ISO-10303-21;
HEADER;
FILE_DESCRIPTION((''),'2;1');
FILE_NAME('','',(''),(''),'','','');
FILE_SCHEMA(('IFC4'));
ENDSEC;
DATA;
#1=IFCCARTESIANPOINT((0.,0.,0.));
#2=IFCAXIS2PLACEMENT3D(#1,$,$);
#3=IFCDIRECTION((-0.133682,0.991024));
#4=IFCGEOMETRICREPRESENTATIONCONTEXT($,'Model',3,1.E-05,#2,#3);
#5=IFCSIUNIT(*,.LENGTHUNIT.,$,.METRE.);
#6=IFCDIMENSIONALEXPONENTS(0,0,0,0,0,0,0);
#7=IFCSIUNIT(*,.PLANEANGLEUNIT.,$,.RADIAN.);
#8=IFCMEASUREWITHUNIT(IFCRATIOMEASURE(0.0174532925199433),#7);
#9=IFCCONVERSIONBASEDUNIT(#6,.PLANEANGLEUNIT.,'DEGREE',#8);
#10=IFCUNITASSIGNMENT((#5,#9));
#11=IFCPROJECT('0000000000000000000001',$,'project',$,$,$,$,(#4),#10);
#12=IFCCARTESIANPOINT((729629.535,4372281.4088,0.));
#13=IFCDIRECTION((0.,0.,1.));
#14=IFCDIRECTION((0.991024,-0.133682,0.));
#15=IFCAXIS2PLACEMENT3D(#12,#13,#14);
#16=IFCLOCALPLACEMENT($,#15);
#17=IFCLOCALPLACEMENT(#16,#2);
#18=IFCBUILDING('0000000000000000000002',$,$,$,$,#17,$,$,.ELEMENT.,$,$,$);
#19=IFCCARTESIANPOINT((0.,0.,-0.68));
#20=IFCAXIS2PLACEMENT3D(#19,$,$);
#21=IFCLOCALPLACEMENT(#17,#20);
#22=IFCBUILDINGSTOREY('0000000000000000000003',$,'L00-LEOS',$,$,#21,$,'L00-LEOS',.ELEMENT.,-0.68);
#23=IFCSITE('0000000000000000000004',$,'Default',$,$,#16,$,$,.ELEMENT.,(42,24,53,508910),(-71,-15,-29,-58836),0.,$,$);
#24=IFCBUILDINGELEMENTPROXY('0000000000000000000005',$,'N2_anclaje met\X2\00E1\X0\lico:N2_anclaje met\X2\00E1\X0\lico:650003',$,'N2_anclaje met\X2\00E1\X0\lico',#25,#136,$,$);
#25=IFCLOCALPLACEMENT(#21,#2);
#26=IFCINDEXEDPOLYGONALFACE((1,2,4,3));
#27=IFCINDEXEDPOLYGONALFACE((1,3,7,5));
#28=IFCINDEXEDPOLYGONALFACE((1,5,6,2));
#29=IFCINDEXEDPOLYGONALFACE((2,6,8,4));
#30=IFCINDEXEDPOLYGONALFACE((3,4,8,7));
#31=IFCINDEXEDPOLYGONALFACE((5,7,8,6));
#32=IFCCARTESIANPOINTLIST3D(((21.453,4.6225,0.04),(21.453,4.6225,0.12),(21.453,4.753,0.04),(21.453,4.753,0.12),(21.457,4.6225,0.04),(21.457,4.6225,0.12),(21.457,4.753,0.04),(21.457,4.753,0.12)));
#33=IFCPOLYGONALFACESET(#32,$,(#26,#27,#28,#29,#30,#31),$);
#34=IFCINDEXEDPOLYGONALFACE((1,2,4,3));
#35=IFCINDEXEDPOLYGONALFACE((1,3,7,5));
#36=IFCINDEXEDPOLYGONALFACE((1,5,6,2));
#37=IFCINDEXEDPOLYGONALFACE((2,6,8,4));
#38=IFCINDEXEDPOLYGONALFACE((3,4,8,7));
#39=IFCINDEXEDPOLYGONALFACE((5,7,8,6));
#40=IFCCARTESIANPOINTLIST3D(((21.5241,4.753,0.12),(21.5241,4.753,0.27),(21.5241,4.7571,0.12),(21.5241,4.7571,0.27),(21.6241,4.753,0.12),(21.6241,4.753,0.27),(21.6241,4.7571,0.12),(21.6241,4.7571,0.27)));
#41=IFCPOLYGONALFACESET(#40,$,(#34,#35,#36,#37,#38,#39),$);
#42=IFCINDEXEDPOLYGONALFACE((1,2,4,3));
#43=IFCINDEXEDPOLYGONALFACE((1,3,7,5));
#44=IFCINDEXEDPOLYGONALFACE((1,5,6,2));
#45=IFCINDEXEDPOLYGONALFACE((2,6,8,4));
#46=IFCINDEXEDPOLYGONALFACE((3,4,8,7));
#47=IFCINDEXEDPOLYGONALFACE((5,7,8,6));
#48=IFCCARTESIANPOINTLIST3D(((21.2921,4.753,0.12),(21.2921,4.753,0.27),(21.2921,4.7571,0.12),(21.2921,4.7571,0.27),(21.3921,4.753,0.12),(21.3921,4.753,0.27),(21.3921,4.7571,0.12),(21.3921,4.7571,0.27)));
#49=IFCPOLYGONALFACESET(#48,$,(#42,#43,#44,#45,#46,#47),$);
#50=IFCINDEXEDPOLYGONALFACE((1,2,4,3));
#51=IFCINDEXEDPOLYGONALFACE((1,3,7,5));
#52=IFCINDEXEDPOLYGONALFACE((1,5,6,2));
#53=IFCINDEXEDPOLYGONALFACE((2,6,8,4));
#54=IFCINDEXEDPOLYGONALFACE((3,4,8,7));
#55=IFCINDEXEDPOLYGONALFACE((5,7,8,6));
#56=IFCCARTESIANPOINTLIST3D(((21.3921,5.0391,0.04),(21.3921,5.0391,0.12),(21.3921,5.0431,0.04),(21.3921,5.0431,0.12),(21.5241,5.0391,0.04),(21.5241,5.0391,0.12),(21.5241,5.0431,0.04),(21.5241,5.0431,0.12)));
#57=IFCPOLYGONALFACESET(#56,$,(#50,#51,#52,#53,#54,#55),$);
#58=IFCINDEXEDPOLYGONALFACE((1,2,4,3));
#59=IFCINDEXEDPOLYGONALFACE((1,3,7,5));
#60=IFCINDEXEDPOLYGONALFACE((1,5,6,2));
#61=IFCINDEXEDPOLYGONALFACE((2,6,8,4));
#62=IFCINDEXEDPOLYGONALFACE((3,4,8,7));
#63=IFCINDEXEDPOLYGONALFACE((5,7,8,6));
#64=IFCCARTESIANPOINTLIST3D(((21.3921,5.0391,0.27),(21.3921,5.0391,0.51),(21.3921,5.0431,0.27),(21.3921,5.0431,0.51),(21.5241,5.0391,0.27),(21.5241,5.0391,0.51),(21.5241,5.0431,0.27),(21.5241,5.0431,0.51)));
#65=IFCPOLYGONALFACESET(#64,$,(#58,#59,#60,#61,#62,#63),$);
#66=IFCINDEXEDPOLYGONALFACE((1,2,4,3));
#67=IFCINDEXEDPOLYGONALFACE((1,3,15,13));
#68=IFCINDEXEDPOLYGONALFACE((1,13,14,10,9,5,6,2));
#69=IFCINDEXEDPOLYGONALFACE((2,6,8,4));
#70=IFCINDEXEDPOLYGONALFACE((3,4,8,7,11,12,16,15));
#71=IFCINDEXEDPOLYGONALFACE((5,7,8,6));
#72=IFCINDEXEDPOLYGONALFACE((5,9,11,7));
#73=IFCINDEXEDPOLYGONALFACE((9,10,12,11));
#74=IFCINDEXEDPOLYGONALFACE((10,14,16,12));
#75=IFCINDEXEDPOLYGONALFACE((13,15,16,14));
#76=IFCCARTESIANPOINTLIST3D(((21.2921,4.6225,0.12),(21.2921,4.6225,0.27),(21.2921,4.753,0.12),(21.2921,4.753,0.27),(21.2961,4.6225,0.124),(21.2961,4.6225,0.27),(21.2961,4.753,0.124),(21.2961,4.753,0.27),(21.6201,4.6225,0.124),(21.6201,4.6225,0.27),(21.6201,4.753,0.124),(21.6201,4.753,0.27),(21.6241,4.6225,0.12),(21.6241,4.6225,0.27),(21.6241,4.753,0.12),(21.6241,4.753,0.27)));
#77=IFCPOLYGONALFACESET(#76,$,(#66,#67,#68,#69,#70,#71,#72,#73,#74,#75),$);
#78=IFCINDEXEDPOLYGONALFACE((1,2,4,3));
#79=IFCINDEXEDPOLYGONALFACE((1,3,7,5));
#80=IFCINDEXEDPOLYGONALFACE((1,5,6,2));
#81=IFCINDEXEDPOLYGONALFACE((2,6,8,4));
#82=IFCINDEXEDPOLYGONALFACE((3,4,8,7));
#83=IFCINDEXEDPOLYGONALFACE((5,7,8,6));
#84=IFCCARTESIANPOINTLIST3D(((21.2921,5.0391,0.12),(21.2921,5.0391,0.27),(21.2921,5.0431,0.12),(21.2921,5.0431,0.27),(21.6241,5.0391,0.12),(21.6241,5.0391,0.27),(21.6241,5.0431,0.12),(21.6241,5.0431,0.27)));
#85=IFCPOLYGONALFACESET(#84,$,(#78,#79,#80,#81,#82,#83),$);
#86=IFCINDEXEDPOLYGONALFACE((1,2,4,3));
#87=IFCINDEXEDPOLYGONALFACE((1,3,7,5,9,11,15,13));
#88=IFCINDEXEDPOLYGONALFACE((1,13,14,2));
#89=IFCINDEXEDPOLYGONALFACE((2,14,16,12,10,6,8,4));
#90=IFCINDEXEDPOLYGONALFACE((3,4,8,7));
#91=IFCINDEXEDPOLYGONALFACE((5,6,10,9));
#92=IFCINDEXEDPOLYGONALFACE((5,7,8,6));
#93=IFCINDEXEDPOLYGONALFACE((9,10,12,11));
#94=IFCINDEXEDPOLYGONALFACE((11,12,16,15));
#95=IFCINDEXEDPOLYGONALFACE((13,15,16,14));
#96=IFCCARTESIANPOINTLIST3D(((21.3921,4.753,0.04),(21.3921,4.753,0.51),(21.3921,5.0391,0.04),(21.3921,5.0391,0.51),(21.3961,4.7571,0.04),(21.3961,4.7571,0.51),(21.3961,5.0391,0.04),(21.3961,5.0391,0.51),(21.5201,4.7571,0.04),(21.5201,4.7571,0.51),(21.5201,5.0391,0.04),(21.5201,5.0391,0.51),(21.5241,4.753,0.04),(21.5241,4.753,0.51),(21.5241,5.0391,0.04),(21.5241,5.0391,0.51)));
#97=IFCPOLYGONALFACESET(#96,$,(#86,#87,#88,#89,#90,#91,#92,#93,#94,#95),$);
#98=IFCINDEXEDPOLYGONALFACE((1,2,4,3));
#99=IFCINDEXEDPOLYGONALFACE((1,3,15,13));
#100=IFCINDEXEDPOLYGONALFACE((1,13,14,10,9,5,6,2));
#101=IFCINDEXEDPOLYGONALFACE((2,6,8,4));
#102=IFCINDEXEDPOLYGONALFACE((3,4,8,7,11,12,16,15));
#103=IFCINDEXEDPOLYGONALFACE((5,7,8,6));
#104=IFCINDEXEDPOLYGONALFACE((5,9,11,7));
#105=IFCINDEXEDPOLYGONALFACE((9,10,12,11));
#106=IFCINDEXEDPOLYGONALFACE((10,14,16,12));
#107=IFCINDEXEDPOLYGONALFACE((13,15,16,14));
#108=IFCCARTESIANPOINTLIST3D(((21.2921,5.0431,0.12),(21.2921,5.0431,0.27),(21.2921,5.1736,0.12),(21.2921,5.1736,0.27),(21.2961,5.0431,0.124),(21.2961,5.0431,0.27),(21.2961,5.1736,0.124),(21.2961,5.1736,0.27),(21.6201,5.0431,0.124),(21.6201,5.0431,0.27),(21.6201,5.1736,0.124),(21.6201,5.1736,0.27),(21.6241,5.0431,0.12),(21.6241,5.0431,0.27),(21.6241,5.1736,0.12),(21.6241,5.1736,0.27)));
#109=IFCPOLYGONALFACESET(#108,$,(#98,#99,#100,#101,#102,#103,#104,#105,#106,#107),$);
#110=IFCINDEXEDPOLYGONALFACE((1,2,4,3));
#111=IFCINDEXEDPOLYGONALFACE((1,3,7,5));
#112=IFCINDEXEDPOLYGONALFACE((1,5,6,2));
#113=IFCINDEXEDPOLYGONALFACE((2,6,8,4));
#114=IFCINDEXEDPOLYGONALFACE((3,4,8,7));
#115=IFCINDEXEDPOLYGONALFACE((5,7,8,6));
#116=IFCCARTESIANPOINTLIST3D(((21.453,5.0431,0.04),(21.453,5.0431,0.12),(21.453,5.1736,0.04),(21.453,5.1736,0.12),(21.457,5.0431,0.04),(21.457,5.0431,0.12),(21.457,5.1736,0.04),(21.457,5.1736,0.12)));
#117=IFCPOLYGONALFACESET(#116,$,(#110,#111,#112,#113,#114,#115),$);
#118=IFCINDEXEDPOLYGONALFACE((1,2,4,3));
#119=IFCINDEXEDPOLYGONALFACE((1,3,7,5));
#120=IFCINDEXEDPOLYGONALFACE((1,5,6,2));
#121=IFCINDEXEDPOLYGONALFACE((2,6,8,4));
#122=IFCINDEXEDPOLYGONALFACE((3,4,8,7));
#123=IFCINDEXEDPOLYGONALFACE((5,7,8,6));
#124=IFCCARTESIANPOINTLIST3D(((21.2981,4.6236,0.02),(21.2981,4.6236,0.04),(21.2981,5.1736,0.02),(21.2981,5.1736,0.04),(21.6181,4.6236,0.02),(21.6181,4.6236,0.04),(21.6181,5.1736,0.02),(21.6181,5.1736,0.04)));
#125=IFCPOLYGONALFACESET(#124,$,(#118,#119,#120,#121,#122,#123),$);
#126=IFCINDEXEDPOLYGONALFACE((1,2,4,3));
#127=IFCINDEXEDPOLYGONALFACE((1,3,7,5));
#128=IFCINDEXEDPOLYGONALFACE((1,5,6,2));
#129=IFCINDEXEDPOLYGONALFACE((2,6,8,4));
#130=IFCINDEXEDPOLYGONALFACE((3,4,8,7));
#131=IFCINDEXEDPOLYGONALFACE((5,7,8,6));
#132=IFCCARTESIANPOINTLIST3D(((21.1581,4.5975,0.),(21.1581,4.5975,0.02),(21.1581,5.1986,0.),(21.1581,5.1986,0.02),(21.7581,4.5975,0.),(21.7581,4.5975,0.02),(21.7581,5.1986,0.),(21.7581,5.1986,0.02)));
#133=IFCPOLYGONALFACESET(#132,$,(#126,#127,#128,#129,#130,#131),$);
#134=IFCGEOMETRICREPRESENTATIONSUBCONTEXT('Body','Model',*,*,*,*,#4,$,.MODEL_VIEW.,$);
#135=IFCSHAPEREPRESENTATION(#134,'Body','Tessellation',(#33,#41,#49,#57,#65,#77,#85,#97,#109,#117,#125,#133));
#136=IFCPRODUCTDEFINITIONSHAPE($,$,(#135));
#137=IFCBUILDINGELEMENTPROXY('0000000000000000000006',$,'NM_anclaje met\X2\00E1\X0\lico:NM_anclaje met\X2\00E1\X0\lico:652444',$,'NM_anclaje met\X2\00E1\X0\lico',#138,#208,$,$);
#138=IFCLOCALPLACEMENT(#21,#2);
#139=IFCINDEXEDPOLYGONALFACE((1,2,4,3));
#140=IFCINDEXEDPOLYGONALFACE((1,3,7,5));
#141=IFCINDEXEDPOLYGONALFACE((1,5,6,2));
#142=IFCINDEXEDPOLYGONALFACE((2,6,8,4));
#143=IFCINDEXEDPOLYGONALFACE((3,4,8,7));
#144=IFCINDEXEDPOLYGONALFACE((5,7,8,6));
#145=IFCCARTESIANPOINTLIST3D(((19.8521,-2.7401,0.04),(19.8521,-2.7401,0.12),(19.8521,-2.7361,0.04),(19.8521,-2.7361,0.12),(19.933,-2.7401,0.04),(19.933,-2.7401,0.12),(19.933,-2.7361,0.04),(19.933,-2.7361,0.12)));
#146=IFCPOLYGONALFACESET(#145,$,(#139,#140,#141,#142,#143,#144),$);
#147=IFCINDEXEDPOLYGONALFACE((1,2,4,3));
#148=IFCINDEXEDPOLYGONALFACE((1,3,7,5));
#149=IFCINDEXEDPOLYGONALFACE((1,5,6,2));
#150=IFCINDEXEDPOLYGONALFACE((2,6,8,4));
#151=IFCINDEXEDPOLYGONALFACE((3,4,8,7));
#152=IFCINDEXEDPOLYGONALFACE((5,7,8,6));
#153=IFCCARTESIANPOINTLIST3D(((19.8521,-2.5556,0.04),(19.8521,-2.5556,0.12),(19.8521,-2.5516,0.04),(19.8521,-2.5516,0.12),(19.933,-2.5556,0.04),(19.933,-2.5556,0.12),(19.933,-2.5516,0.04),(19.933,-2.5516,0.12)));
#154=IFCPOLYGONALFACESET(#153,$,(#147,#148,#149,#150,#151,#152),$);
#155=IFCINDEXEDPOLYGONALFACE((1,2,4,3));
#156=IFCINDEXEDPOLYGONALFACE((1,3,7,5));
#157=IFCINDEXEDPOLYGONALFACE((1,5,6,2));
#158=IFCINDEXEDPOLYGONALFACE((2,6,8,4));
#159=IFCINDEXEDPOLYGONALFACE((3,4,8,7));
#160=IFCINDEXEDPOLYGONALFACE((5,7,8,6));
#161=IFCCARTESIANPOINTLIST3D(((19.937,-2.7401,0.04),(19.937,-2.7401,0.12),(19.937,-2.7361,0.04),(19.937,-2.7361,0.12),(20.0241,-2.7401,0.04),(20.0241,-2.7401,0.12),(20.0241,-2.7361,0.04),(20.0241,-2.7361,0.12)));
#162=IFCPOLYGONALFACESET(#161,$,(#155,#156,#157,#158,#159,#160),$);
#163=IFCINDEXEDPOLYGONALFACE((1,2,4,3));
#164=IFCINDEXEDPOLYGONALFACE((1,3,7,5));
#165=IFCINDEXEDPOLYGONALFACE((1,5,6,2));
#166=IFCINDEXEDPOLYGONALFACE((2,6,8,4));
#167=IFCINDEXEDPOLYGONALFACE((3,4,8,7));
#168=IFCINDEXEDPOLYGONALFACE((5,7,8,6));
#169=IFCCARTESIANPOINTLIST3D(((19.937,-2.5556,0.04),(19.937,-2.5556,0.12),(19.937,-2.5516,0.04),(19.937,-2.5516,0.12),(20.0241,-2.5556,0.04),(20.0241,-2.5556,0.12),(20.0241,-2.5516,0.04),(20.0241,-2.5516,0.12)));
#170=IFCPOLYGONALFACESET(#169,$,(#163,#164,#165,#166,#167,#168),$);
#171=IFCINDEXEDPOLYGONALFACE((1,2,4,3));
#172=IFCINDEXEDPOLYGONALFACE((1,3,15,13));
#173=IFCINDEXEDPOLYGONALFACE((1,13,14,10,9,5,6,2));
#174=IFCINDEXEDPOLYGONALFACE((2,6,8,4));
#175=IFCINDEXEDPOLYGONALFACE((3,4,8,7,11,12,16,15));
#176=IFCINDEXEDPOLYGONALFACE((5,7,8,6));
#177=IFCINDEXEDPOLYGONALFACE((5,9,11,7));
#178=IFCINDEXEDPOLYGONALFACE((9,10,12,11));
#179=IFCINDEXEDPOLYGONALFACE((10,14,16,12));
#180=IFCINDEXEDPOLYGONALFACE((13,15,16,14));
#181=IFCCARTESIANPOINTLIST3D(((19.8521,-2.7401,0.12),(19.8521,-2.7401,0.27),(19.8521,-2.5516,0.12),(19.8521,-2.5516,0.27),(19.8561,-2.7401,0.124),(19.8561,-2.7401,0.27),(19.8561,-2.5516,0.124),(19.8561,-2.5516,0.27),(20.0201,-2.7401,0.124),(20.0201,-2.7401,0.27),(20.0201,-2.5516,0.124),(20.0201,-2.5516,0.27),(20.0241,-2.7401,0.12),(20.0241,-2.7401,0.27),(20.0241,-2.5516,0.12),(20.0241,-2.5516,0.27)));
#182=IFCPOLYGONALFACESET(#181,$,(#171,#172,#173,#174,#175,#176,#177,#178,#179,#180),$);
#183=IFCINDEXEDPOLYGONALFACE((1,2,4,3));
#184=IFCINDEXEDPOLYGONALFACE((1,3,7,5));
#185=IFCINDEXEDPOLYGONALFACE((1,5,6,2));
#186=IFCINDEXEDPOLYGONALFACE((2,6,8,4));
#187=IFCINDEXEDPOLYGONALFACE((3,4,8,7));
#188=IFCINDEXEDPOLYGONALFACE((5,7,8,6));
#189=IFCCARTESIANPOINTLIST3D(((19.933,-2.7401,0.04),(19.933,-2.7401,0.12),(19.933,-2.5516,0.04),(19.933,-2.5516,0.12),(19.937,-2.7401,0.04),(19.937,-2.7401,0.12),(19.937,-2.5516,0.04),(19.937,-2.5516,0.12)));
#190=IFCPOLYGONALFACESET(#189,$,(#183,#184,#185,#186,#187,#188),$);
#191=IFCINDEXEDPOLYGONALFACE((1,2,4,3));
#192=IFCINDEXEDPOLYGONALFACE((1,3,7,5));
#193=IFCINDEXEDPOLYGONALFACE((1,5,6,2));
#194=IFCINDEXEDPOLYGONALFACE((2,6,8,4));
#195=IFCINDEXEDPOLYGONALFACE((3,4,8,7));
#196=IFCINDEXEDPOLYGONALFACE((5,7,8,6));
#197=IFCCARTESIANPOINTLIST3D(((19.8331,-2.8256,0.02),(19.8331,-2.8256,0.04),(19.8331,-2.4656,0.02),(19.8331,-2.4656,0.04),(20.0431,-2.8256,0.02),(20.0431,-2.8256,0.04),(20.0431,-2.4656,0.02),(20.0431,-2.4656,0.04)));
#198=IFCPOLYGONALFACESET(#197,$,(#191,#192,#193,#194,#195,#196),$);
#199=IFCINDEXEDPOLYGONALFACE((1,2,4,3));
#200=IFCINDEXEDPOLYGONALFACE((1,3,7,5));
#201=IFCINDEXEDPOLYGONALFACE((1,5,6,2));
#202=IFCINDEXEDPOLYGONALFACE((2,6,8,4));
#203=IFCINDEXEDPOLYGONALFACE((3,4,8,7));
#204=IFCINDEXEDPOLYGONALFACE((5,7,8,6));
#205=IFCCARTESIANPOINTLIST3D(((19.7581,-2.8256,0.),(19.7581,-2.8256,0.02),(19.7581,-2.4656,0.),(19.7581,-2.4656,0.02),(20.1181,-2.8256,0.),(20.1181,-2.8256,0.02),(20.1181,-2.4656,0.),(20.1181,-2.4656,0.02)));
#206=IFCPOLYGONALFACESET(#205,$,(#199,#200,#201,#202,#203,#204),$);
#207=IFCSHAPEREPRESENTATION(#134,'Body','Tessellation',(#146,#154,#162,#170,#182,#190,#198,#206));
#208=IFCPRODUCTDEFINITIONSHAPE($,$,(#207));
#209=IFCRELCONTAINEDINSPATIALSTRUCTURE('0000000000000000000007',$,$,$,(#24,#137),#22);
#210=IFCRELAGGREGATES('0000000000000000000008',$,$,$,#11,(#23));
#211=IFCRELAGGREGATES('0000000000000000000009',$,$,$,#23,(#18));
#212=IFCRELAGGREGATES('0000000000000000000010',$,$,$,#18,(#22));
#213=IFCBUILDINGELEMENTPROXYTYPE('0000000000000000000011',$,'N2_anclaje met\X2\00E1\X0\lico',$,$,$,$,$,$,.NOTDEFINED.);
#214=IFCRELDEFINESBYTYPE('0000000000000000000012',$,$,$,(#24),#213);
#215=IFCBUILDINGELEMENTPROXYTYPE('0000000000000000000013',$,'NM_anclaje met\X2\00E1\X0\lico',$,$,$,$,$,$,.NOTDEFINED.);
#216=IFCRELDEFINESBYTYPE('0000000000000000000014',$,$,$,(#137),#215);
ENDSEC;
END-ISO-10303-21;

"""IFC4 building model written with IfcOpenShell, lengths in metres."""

from ifc_helpers import new_model, entity, si_unit, converted_unit, direction, frame, frame_2d, origin, origin_2d_with_axis, place, context, subcontext, project, spatial, polyline, rectangle, outline, extrude, source, transform, mapped, type_object, type_shapes, element, save


model = new_model("IFC4")

# Units and contexts
model_context = context("Model", 3, precision=1e-05, world=origin(), true_north=direction((-0.133682, 0.991024)))
body_context = subcontext(model_context, "Body", "Model", "MODEL_VIEW")
ifc_project = project(units=[si_unit("LENGTHUNIT", "METRE"), converted_unit("PLANEANGLEUNIT", "DEGREE", entity("IfcRatioMeasure", 0.0174532925199433), si_unit("PLANEANGLEUNIT", "RADIAN"), dimensions=[0, 0, 0, 0, 0, 0, 0])], contexts=[model_context])

# Site, building, storey
site_placement = place(None, frame((729629.535, 4372281.4088, 0.0), z_axis=(0.0, 0.0, 1.0), x_axis=(0.991024, -0.133682, 0.0)))
site = spatial("IfcSite", under=ifc_project, at=site_placement, Name="Default", CompositionType="ELEMENT", RefLatitude=(42, 24, 53, 508910), RefLongitude=(-71, -15, -29, -58836), RefElevation=0.0)
building_placement = place(site_placement, origin())
building = spatial("IfcBuilding", under=site, at=building_placement, CompositionType="ELEMENT")
storey_placement = place(building_placement, frame((0.0, 0.0, -0.68)))
storey = spatial("IfcBuildingStorey", under=building, at=storey_placement, Name="L00-LEOS", LongName="L00-LEOS", CompositionType="ELEMENT", Elevation=-0.68)

# Building element proxies
building_element_proxy_type_1 = type_object("IfcBuildingElementProxyType", Name="N2_anclaje metálico")
shared_shape_1 = source(origin(), body_context, "Body", "SweptSolid", [
    extrude(rectangle(XDim=0.004, YDim=0.1305, at=origin_2d_with_axis()), frame((0.2103, 0.0, 0.04), z_axis=(0.0, 0.0, 1.0), x_axis=(0.0, -1.0, 0.0)), (0.0, 0.0, 1.0), 0.08),
    extrude(rectangle(XDim=0.1, YDim=0.0042, at=frame_2d((0.0, 0.0), x_axis=(1.0, 0.0))), frame((0.143, 0.1191, 0.12), z_axis=(0.0, 0.0, 1.0), x_axis=(0.0, 1.0, 0.0)), (0.0, 0.0, 1.0), 0.15),
    extrude(rectangle(XDim=0.1, YDim=0.0042, at=origin_2d_with_axis()), frame((0.143, -0.1129, 0.12), z_axis=(0.0, 0.0, 1.0), x_axis=(0.0, 1.0, 0.0)), (0.0, 0.0, 1.0), 0.15),
    extrude(rectangle(XDim=0.132, YDim=0.004, at=frame_2d((0.0, 0.0), x_axis=(1.0, 0.0))), frame((-0.1431, 0.0031, 0.04), z_axis=(0.0, 0.0, 1.0), x_axis=(0.0, 1.0, 0.0)), (0.0, 0.0, 1.0), 0.08),
    extrude(rectangle(XDim=0.132, YDim=0.004, at=frame_2d((0.0, 0.0), x_axis=(1.0, 0.0))), frame((-0.1431, 0.0031, 0.27), z_axis=(0.0, 0.0, 1.0), x_axis=(0.0, 1.0, 0.0)), (0.0, 0.0, 1.0), 0.24),
    extrude(outline(polyline([(-0.076, -0.166), (0.074, -0.166), (0.074, -0.162), (-0.072, -0.162), (-0.072, 0.162), (0.074, 0.162), (0.074, 0.166), (-0.076, 0.166), (-0.076, -0.166)])), frame((0.1451, 0.0031, 0.196), z_axis=(1.0, 0.0, 0.0), x_axis=(0.0, 0.0, 1.0)), (0.0, 0.0, 1.0), 0.1305),
    extrude(rectangle(XDim=0.332, YDim=0.004, at=origin_2d_with_axis()), frame((-0.1431, 0.0031, 0.12), z_axis=(0.0, 0.0, 1.0), x_axis=(0.0, 1.0, 0.0)), (0.0, 0.0, 1.0), 0.15),
    extrude(outline(polyline([(-0.1441, -0.066), (0.142, -0.066), (0.142, -0.062), (-0.14, -0.062), (-0.14, 0.062), (0.142, 0.062), (0.142, 0.066), (-0.1441, 0.066), (-0.1441, -0.066)])), frame((0.001, 0.0031, 0.04), z_axis=(0.0, 0.0, 1.0), x_axis=(-1.0, 0.0, 0.0)), (0.0, 0.0, 1.0), 0.47),
    extrude(outline(polyline([(-0.076, -0.166), (0.074, -0.166), (0.074, -0.162), (-0.072, -0.162), (-0.072, 0.162), (0.074, 0.162), (0.074, 0.166), (-0.076, 0.166), (-0.076, -0.166)])), frame((-0.2756, 0.0031, 0.196), z_axis=(1.0, 0.0, 0.0), x_axis=(0.0, 0.0, 1.0)), (0.0, 0.0, 1.0), 0.1305),
    extrude(rectangle(XDim=0.004, YDim=0.1305, at=origin_2d_with_axis()), frame((-0.2103, 0.0, 0.04), z_axis=(0.0, 0.0, 1.0), x_axis=(0.0, -1.0, 0.0)), (0.0, 0.0, 1.0), 0.08),
    extrude(rectangle(XDim=0.55, YDim=0.32, at=frame_2d((0.0, 0.0), x_axis=(1.0, 0.0))), frame((-0.0006, 0.0031, 0.02), z_axis=(0.0, 0.0, 1.0), x_axis=(-1.0, 0.0, 0.0)), (0.0, 0.0, 1.0), 0.02),
    extrude(rectangle(XDim=0.6012, YDim=0.6, at=frame_2d((0.0, 0.0), x_axis=(1.0, 0.0))), frame((0.0, 0.0031, 0.0), z_axis=(0.0, 0.0, 1.0), x_axis=(-1.0, 0.0, 0.0)), (0.0, 0.0, 1.0), 0.02),
])
type_shapes(building_element_proxy_type_1, [shared_shape_1])
for number, where, z_axis, x_axis, name in (
    (1, (21.455, 4.8981, 0.0), (0.0, 0.0, 1.0), (0.0, -1.0, 0.0), "N2_anclaje metálico:N2_anclaje metálico:650003"),
):
    element("IfcBuildingElementProxy", number, at=place(storey_placement, frame(where, z_axis=z_axis, x_axis=x_axis)), inside=storey, type_object=building_element_proxy_type_1, Name=name, ObjectType="N2_anclaje metálico", context=body_context, shape_type="MappedRepresentation", body=[
        mapped(shared_shape_1, transform((0.0, 0.0, 0.0), scale=1.0)),
    ])
building_element_proxy_type_2 = type_object("IfcBuildingElementProxyType", Name="NM_anclaje metálico")
shared_shape_2 = source(origin(), body_context, "Body", "SweptSolid", [
    extrude(rectangle(XDim=0.0809, YDim=0.004, at=frame_2d((0.0, 0.0), x_axis=(1.0, 0.0))), frame((0.0925, -0.0424, 0.04), z_axis=(0.0, 0.0, 1.0), x_axis=(0.0, 1.0, 0.0)), (0.0, 0.0, 1.0), 0.08),
    extrude(rectangle(XDim=0.0809, YDim=0.004, at=frame_2d((0.0, 0.0), x_axis=(1.0, 0.0))), frame((-0.092, -0.0424, 0.04), z_axis=(0.0, 0.0, 1.0), x_axis=(0.0, 1.0, 0.0)), (0.0, 0.0, 1.0), 0.08),
    extrude(rectangle(XDim=0.0871, YDim=0.004, at=origin_2d_with_axis()), frame((0.0925, 0.0456, 0.04), z_axis=(0.0, 0.0, 1.0), x_axis=(0.0, 1.0, 0.0)), (0.0, 0.0, 1.0), 0.08),
    extrude(rectangle(XDim=0.0871, YDim=0.004, at=frame_2d((0.0, 0.0), x_axis=(1.0, 0.0))), frame((-0.092, 0.0456, 0.04), z_axis=(0.0, 0.0, 1.0), x_axis=(0.0, 1.0, 0.0)), (0.0, 0.0, 1.0), 0.08),
    extrude(outline(polyline([(-0.076, -0.086), (0.074, -0.086), (0.074, -0.082), (-0.072, -0.082), (-0.072, 0.082), (0.074, 0.082), (0.074, 0.086), (-0.076, 0.086), (-0.076, -0.086)])), frame((-0.094, 0.0031, 0.196), z_axis=(1.0, 0.0, 0.0), x_axis=(0.0, 0.0, 1.0)), (0.0, 0.0, 1.0), 0.1885),
    extrude(rectangle(XDim=0.004, YDim=0.1885, at=frame_2d((0.0, 0.0), x_axis=(1.0, 0.0))), frame((0.0002, 0.0, 0.04), z_axis=(0.0, 0.0, 1.0), x_axis=(0.0, -1.0, 0.0)), (0.0, 0.0, 1.0), 0.08),
    extrude(rectangle(XDim=0.36, YDim=0.21, at=frame_2d((0.0, 0.0), x_axis=(1.0, 0.0))), frame((0.0, 0.0031, 0.02), z_axis=(0.0, 0.0, 1.0), x_axis=(-1.0, 0.0, 0.0)), (0.0, 0.0, 1.0), 0.02),
    extrude(rectangle(XDim=0.36, YDim=0.36, at=frame_2d((0.0, 0.0), x_axis=(1.0, 0.0))), frame((0.0, 0.0031, 0.0), z_axis=(0.0, 0.0, 1.0), x_axis=(-1.0, 0.0, 0.0)), (0.0, 0.0, 1.0), 0.02),
])
type_shapes(building_element_proxy_type_2, [shared_shape_2])
for number, where, z_axis, x_axis, name in (
    (2, (19.935, -2.6456, 0.0), (0.0, 0.0, 1.0), (0.0, -1.0, 0.0), "NM_anclaje metálico:NM_anclaje metálico:652444"),
):
    element("IfcBuildingElementProxy", number, at=place(storey_placement, frame(where, z_axis=z_axis, x_axis=x_axis)), inside=storey, type_object=building_element_proxy_type_2, Name=name, ObjectType="NM_anclaje metálico", context=body_context, shape_type="MappedRepresentation", body=[
        mapped(shared_shape_2, transform((0.0, 0.0, 0.0), scale=1.0)),
    ])

save(model, "model.ifc")
